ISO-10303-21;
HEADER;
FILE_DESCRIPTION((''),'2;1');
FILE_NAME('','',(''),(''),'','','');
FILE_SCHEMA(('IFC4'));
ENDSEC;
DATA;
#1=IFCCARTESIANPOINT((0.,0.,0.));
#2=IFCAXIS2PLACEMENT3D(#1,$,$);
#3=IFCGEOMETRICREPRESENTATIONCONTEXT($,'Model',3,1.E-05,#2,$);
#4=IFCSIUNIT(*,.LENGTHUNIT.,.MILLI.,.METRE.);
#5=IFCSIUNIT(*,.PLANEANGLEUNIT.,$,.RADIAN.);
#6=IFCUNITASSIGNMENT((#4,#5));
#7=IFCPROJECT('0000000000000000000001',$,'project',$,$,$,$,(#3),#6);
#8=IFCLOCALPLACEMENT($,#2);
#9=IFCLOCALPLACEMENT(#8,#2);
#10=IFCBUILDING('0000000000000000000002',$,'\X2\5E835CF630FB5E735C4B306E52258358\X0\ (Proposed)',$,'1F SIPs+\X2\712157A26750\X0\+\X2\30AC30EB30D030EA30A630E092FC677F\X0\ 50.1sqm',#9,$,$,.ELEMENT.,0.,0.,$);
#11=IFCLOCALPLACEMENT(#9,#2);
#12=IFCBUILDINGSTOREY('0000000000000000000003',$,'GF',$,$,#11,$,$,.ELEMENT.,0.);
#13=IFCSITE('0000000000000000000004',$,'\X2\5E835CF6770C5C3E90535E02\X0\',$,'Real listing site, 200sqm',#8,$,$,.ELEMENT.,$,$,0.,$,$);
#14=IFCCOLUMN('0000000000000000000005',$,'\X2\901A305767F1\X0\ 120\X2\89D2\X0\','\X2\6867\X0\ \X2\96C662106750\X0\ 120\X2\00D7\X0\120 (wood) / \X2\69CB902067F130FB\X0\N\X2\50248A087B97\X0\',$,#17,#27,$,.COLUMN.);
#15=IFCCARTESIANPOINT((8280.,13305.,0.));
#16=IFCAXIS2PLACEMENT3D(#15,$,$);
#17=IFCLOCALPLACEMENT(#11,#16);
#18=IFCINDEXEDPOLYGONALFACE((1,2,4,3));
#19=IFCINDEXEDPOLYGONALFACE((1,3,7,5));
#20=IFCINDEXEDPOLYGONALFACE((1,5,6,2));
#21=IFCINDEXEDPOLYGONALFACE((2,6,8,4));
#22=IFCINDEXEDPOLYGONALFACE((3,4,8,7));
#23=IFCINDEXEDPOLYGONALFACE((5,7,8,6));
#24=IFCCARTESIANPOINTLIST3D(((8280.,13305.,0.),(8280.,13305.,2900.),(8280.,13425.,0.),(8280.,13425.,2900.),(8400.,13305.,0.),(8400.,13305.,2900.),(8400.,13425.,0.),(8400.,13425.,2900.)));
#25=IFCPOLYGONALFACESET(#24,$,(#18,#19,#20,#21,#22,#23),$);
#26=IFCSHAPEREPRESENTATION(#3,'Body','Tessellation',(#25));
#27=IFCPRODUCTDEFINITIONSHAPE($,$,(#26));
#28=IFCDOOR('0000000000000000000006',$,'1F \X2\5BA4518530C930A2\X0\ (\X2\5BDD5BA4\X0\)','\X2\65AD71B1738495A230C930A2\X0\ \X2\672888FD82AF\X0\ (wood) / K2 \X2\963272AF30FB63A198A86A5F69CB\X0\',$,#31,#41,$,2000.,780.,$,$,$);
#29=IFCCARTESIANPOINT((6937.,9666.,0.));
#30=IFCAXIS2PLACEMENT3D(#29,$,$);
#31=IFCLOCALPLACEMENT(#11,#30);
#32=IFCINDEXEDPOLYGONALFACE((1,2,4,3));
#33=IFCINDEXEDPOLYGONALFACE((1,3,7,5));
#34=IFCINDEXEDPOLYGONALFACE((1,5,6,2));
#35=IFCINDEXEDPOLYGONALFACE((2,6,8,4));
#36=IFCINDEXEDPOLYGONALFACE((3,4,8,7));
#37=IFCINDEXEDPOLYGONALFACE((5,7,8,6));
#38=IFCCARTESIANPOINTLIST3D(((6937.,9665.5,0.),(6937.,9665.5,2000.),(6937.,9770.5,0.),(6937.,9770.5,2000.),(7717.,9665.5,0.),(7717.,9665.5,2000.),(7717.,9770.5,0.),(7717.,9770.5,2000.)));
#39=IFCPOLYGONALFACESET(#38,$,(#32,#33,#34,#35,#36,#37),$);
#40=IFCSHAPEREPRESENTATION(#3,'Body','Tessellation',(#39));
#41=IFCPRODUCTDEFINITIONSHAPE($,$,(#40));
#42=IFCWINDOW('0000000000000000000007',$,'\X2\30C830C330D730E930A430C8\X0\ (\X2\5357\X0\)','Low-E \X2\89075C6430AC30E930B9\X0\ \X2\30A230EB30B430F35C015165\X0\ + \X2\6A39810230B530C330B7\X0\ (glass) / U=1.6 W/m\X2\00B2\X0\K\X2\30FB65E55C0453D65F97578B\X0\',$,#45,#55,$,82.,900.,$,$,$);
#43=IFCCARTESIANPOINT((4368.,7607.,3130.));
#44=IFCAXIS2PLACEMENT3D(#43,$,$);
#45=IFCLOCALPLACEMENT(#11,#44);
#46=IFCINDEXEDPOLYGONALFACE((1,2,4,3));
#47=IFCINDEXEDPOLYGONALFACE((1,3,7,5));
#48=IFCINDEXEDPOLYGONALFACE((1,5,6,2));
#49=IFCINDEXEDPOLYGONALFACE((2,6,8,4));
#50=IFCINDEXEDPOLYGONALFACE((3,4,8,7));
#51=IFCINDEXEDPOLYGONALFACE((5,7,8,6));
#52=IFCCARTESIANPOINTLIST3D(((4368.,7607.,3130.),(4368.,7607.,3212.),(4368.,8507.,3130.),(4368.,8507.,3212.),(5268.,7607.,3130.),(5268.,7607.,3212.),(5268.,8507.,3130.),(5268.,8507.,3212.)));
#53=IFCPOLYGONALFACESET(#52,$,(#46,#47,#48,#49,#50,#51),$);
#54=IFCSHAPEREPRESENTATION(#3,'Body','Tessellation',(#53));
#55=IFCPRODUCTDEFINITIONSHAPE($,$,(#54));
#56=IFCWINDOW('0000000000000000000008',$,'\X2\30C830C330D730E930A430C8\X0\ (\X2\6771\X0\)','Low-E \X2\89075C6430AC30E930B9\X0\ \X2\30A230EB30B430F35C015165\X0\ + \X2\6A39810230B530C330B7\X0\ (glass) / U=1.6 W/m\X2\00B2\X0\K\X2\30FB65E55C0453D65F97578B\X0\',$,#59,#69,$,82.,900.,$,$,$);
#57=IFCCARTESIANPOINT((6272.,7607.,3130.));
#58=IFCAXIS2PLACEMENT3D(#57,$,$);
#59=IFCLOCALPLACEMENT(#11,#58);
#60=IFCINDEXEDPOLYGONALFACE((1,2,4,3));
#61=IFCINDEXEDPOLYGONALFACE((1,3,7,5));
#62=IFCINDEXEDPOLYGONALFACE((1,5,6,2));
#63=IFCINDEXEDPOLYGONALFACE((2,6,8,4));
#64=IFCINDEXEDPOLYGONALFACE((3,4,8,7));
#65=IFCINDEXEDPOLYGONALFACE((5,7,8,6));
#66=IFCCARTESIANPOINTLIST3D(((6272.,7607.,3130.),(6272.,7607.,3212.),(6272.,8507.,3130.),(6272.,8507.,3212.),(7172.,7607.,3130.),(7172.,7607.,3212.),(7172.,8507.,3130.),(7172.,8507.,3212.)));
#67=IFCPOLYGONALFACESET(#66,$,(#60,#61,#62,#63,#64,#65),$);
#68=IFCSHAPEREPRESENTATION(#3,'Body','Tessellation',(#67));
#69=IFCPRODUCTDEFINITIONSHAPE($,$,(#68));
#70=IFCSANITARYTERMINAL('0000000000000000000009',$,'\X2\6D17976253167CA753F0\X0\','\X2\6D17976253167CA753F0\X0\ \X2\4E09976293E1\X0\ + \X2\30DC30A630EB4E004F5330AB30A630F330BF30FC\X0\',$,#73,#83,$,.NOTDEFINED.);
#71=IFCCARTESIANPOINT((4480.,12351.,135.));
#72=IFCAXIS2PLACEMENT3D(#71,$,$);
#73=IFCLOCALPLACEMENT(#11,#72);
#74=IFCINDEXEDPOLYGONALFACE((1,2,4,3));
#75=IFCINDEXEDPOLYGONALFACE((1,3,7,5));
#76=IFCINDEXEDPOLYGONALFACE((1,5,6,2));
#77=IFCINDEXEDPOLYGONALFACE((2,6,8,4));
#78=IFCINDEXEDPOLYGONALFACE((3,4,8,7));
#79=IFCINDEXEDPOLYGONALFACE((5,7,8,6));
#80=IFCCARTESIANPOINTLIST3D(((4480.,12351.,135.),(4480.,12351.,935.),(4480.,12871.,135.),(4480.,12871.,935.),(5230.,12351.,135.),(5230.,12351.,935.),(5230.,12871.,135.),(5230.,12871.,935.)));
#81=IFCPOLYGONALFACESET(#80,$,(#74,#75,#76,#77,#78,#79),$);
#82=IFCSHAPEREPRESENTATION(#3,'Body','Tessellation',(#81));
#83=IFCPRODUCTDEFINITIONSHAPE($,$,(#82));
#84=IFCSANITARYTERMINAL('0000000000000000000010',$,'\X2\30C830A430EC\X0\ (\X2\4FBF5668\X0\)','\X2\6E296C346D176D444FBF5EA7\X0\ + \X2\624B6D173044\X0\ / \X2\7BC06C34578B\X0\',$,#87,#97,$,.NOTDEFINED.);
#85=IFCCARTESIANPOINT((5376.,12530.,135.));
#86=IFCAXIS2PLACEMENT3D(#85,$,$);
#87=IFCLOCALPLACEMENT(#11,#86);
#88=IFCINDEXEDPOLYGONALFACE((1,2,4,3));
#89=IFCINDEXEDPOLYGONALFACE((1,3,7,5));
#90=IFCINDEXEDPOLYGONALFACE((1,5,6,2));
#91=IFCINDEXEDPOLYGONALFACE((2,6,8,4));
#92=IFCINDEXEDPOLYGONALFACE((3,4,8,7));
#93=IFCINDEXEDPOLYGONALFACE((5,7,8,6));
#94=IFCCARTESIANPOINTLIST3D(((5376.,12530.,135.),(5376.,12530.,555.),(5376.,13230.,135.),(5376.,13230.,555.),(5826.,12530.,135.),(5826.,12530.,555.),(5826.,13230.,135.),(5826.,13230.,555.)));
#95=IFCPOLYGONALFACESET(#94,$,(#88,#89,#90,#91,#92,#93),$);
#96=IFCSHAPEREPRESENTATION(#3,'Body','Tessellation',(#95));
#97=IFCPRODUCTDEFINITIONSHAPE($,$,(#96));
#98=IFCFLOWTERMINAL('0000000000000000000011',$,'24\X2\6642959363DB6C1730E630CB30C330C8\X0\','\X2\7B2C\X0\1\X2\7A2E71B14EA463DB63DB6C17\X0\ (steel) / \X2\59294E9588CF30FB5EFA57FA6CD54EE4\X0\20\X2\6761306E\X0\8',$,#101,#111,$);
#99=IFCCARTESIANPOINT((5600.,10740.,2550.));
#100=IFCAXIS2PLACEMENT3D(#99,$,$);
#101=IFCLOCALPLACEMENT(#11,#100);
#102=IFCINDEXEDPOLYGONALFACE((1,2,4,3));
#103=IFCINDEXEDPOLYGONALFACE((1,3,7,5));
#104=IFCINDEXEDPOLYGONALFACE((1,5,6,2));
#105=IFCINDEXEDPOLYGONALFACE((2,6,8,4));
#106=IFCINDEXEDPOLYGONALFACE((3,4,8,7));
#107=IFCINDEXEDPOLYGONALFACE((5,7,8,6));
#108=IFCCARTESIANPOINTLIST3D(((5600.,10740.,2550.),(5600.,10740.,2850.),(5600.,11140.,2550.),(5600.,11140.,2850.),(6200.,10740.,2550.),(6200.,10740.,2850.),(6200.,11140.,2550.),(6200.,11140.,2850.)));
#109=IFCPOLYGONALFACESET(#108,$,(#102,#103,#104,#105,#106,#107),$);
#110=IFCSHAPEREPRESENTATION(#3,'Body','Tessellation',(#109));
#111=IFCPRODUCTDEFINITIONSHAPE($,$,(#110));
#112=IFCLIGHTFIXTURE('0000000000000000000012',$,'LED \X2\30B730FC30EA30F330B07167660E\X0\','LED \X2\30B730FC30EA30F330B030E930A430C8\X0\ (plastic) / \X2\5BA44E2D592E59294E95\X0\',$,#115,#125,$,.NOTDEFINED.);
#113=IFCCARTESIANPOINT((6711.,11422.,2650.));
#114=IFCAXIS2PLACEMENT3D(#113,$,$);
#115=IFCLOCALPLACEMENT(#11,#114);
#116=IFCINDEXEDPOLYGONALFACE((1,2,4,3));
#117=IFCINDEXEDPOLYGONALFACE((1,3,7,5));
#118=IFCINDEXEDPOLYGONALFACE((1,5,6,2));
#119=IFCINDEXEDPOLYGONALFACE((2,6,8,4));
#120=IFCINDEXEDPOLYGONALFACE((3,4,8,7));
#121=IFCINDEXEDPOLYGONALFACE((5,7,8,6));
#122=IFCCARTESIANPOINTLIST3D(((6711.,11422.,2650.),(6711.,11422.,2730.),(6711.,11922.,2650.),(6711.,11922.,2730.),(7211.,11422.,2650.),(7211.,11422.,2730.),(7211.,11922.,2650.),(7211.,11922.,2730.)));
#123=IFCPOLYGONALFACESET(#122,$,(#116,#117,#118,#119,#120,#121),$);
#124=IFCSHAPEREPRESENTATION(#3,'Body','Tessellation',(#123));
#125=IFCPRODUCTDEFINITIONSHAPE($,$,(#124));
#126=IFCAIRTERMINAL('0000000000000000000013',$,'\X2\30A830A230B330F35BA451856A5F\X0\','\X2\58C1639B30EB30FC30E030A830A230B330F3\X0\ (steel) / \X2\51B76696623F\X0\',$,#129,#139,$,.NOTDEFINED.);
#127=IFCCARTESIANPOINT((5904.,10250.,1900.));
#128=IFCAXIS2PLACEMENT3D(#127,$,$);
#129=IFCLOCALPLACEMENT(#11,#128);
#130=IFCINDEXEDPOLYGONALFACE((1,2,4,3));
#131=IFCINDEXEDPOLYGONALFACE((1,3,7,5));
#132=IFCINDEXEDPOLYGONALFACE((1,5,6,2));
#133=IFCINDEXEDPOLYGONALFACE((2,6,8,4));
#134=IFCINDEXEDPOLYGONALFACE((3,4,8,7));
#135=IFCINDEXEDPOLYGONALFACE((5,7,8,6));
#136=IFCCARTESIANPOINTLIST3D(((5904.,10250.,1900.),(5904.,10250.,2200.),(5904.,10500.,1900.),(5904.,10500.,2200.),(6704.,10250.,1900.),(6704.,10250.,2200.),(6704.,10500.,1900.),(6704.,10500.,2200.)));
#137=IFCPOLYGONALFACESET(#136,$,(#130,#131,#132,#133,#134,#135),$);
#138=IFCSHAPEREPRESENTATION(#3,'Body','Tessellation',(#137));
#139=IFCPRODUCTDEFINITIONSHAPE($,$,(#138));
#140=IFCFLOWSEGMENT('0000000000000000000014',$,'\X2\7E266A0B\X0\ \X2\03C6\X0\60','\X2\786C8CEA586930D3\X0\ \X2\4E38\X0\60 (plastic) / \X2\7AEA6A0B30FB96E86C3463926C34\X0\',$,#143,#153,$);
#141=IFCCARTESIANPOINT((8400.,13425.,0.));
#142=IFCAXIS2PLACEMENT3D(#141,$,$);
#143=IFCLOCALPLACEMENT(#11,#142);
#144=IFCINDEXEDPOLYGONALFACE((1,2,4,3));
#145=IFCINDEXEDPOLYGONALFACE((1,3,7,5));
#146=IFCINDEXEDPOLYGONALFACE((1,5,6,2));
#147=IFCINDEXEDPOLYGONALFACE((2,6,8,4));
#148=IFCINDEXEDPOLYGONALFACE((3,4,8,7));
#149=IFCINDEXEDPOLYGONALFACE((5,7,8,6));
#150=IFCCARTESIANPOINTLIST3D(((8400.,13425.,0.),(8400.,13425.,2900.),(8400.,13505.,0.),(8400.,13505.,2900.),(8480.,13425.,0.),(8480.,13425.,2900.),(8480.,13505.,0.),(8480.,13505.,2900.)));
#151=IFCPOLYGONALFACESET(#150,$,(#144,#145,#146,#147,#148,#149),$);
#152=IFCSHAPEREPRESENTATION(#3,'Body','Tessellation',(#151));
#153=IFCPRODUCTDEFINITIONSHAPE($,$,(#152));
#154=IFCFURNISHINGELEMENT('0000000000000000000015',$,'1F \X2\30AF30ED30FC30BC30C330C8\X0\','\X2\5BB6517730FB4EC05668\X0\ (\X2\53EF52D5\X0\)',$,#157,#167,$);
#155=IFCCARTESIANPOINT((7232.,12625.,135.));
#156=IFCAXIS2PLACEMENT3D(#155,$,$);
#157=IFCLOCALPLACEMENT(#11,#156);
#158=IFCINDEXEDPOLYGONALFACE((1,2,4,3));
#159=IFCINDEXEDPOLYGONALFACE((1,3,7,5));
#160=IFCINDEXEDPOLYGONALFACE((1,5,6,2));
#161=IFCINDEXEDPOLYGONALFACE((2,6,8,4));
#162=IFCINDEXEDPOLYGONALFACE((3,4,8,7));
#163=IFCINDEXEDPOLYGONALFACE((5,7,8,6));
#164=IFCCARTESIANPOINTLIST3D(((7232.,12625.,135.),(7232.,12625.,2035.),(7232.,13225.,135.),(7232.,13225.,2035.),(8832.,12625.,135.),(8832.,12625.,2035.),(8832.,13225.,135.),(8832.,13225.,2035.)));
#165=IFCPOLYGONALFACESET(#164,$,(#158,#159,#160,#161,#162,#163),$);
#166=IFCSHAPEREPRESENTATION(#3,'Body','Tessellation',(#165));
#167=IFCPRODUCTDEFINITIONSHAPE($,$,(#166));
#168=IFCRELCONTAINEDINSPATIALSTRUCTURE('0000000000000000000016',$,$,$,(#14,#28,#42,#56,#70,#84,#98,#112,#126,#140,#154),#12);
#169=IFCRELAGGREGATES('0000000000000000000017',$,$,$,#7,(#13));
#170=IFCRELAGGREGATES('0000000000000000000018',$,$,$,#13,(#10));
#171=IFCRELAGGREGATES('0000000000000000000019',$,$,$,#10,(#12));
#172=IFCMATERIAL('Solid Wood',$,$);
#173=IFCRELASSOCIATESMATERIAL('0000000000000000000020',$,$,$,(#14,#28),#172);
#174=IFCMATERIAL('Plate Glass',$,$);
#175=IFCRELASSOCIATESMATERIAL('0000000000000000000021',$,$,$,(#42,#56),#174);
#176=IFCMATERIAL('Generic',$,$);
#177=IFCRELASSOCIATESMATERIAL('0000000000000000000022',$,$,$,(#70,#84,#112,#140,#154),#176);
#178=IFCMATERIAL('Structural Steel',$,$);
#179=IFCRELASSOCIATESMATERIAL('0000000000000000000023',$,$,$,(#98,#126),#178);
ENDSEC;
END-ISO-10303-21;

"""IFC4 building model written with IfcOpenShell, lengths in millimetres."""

from ifc_helpers import new_model, si_unit, frame, frame_2d, origin, place, context, project, spatial, rectangle, extrude, material, element, save


model = new_model("IFC4")

# Units and contexts
model_context = context("Model", 3, precision=1e-05, world=origin())
ifc_project = project(units=[si_unit("LENGTHUNIT", "METRE", prefix="MILLI"), si_unit("PLANEANGLEUNIT", "RADIAN")], contexts=[model_context])

# Site, building, storey
site_placement = place(None, origin())
site = spatial("IfcSite", under=ifc_project, at=site_placement, Name="広島県尾道市", ObjectType="Real listing site, 200sqm", CompositionType="ELEMENT", RefElevation=0.0)
building_placement = place(site_placement, origin())
building = spatial("IfcBuilding", under=site, at=building_placement, Name="広島・平屋の別荘 (Proposed)", ObjectType="1F SIPs+無垢材+ガルバリウム鋼板 50.1sqm", CompositionType="ELEMENT", ElevationOfRefHeight=0.0, ElevationOfTerrain=0.0)
storey_placement = place(building_placement, origin())
storey = spatial("IfcBuildingStorey", under=building, at=storey_placement, Name="GF", CompositionType="ELEMENT", Elevation=0.0)

# Column
ifc_material_1 = material(Name="Solid Wood")
column_1_placement = place(storey_placement, frame((8280.0, 13305.0, 0.0)))
element("IfcColumn", 1, at=column_1_placement, inside=storey, material=ifc_material_1, Name="通し柱 120角", Description="桧 集成材 120×120 (wood) / 構造柱・N値計算", PredefinedType="COLUMN", context=model_context, shape_type="SweptSolid", body=[
    extrude(rectangle(XDim=120.0, YDim=120.0, at=frame_2d((60.0, 60.0))), frame((8280.0, 13305.0, 0.0)), (0.0, 0.0, 1.0), 2900.0),
])

# Door
door_placement = place(storey_placement, frame((6937.0, 9666.0, 0.0)))
element("IfcDoor", 2, at=door_placement, inside=storey, material=ifc_material_1, Name="1F 室内ドア (寝室)", Description="断熱玄関ドア 木製芯 (wood) / K2 防犯・採風機構", OverallHeight=2000.0, OverallWidth=780.0, context=model_context, shape_type="SweptSolid", body=[
    extrude(rectangle(XDim=780.0, YDim=105.0, at=frame_2d((390.0, 52.0))), frame((6937.0, 9666.0, 0.0)), (0.0, 0.0, 1.0), 2000.0),
])

# Windows
ifc_material_2 = material(Name="Plate Glass")
window_1_placement = place(storey_placement, frame((4368.0, 7607.0, 3130.0)))
element("IfcWindow", 3, at=window_1_placement, inside=storey, material=ifc_material_2, Name="トップライト (南)", Description="Low-E 複層ガラス アルゴン封入 + 樹脂サッシ (glass) / U=1.6 W/m²K・日射取得型", OverallHeight=82.0, OverallWidth=900.0, context=model_context, shape_type="SweptSolid", body=[
    extrude(rectangle(XDim=900.0, YDim=900.0, at=frame_2d((450.0, 450.0))), frame((4368.0, 7607.0, 3130.0)), (0.0, 0.0, 1.0), 82.0),
])
window_2_placement = place(storey_placement, frame((6272.0, 7607.0, 3130.0)))
element("IfcWindow", 4, at=window_2_placement, inside=storey, material=ifc_material_2, Name="トップライト (東)", Description="Low-E 複層ガラス アルゴン封入 + 樹脂サッシ (glass) / U=1.6 W/m²K・日射取得型", OverallHeight=82.0, OverallWidth=900.0, context=model_context, shape_type="SweptSolid", body=[
    extrude(rectangle(XDim=900.0, YDim=900.0, at=frame_2d((450.0, 450.0))), frame((6272.0, 7607.0, 3130.0)), (0.0, 0.0, 1.0), 82.0),
])

# Sanitary terminals
ifc_material_3 = material(Name="Generic")
sanitary_terminal_1_placement = place(storey_placement, frame((4480.0, 12351.0, 135.0)))
element("IfcSanitaryTerminal", 5, at=sanitary_terminal_1_placement, inside=storey, material=ifc_material_3, Name="洗面化粧台", Description="洗面化粧台 三面鏡 + ボウル一体カウンター", PredefinedType="NOTDEFINED", context=model_context, shape_type="SweptSolid", body=[
    extrude(rectangle(XDim=750.0, YDim=520.0, at=frame_2d((375.0, 260.0))), frame((4480.0, 12351.0, 135.0)), (0.0, 0.0, 1.0), 800.0),
])
sanitary_terminal_2_placement = place(storey_placement, frame((5376.0, 12530.0, 135.0)))
element("IfcSanitaryTerminal", 6, at=sanitary_terminal_2_placement, inside=storey, material=ifc_material_3, Name="トイレ (便器)", Description="温水洗浄便座 + 手洗い / 節水型", PredefinedType="NOTDEFINED", context=model_context, shape_type="SweptSolid", body=[
    extrude(rectangle(XDim=450.0, YDim=700.0, at=frame_2d((225.0, 350.0))), frame((5376.0, 12530.0, 135.0)), (0.0, 0.0, 1.0), 420.0),
])

# Flow terminal
ifc_material_4 = material(Name="Structural Steel")
flow_terminal_placement = place(storey_placement, frame((5600.0, 10740.0, 2550.0)))
element("IfcFlowTerminal", 7, at=flow_terminal_placement, inside=storey, material=ifc_material_4, Name="24時間換気ユニット", Description="第1種熱交換換気 (steel) / 天井裏・建基法令20条の8", context=model_context, shape_type="SweptSolid", body=[
    extrude(rectangle(XDim=600.0, YDim=400.0, at=frame_2d((300.0, 200.0))), frame((5600.0, 10740.0, 2550.0)), (0.0, 0.0, 1.0), 300.0),
])

# Light fixture
light_fixture_placement = place(storey_placement, frame((6711.0, 11422.0, 2650.0)))
element("IfcLightFixture", 8, at=light_fixture_placement, inside=storey, material=ifc_material_3, Name="LED シーリング照明", Description="LED シーリングライト (plastic) / 室中央天井", PredefinedType="NOTDEFINED", context=model_context, shape_type="SweptSolid", body=[
    extrude(rectangle(XDim=500.0, YDim=500.0, at=frame_2d((250.0, 250.0))), frame((6711.0, 11422.0, 2650.0)), (0.0, 0.0, 1.0), 80.0),
])

# Air terminal
air_terminal_placement = place(storey_placement, frame((5904.0, 10250.0, 1900.0)))
element("IfcAirTerminal", 9, at=air_terminal_placement, inside=storey, material=ifc_material_4, Name="エアコン室内機", Description="壁掛ルームエアコン (steel) / 冷暖房", PredefinedType="NOTDEFINED", context=model_context, shape_type="SweptSolid", body=[
    extrude(rectangle(XDim=800.0, YDim=250.0, at=frame_2d((400.0, 125.0))), frame((5904.0, 10250.0, 1900.0)), (0.0, 0.0, 1.0), 300.0),
])

# Flow segment
flow_segment_placement = place(storey_placement, frame((8400.0, 13425.0, 0.0)))
element("IfcFlowSegment", 10, at=flow_segment_placement, inside=storey, material=ifc_material_3, Name="縦樋 φ60", Description="硬質塩ビ 丸60 (plastic) / 竪樋・雨水排水", context=model_context, shape_type="SweptSolid", body=[
    extrude(rectangle(XDim=80.0, YDim=80.0, at=frame_2d((40.0, 40.0))), frame((8400.0, 13425.0, 0.0)), (0.0, 0.0, 1.0), 2900.0),
])

# Furnishing element
furnishing_placement = place(storey_placement, frame((7232.0, 12625.0, 135.0)))
element("IfcFurnishingElement", 11, at=furnishing_placement, inside=storey, material=ifc_material_3, Name="1F クローゼット", Description="家具・什器 (可動)", context=model_context, shape_type="SweptSolid", body=[
    extrude(rectangle(XDim=1600.0, YDim=600.0, at=frame_2d((800.0, 300.0))), frame((7232.0, 12625.0, 135.0)), (0.0, 0.0, 1.0), 1900.0),
])

save(model, "model.ifc")
